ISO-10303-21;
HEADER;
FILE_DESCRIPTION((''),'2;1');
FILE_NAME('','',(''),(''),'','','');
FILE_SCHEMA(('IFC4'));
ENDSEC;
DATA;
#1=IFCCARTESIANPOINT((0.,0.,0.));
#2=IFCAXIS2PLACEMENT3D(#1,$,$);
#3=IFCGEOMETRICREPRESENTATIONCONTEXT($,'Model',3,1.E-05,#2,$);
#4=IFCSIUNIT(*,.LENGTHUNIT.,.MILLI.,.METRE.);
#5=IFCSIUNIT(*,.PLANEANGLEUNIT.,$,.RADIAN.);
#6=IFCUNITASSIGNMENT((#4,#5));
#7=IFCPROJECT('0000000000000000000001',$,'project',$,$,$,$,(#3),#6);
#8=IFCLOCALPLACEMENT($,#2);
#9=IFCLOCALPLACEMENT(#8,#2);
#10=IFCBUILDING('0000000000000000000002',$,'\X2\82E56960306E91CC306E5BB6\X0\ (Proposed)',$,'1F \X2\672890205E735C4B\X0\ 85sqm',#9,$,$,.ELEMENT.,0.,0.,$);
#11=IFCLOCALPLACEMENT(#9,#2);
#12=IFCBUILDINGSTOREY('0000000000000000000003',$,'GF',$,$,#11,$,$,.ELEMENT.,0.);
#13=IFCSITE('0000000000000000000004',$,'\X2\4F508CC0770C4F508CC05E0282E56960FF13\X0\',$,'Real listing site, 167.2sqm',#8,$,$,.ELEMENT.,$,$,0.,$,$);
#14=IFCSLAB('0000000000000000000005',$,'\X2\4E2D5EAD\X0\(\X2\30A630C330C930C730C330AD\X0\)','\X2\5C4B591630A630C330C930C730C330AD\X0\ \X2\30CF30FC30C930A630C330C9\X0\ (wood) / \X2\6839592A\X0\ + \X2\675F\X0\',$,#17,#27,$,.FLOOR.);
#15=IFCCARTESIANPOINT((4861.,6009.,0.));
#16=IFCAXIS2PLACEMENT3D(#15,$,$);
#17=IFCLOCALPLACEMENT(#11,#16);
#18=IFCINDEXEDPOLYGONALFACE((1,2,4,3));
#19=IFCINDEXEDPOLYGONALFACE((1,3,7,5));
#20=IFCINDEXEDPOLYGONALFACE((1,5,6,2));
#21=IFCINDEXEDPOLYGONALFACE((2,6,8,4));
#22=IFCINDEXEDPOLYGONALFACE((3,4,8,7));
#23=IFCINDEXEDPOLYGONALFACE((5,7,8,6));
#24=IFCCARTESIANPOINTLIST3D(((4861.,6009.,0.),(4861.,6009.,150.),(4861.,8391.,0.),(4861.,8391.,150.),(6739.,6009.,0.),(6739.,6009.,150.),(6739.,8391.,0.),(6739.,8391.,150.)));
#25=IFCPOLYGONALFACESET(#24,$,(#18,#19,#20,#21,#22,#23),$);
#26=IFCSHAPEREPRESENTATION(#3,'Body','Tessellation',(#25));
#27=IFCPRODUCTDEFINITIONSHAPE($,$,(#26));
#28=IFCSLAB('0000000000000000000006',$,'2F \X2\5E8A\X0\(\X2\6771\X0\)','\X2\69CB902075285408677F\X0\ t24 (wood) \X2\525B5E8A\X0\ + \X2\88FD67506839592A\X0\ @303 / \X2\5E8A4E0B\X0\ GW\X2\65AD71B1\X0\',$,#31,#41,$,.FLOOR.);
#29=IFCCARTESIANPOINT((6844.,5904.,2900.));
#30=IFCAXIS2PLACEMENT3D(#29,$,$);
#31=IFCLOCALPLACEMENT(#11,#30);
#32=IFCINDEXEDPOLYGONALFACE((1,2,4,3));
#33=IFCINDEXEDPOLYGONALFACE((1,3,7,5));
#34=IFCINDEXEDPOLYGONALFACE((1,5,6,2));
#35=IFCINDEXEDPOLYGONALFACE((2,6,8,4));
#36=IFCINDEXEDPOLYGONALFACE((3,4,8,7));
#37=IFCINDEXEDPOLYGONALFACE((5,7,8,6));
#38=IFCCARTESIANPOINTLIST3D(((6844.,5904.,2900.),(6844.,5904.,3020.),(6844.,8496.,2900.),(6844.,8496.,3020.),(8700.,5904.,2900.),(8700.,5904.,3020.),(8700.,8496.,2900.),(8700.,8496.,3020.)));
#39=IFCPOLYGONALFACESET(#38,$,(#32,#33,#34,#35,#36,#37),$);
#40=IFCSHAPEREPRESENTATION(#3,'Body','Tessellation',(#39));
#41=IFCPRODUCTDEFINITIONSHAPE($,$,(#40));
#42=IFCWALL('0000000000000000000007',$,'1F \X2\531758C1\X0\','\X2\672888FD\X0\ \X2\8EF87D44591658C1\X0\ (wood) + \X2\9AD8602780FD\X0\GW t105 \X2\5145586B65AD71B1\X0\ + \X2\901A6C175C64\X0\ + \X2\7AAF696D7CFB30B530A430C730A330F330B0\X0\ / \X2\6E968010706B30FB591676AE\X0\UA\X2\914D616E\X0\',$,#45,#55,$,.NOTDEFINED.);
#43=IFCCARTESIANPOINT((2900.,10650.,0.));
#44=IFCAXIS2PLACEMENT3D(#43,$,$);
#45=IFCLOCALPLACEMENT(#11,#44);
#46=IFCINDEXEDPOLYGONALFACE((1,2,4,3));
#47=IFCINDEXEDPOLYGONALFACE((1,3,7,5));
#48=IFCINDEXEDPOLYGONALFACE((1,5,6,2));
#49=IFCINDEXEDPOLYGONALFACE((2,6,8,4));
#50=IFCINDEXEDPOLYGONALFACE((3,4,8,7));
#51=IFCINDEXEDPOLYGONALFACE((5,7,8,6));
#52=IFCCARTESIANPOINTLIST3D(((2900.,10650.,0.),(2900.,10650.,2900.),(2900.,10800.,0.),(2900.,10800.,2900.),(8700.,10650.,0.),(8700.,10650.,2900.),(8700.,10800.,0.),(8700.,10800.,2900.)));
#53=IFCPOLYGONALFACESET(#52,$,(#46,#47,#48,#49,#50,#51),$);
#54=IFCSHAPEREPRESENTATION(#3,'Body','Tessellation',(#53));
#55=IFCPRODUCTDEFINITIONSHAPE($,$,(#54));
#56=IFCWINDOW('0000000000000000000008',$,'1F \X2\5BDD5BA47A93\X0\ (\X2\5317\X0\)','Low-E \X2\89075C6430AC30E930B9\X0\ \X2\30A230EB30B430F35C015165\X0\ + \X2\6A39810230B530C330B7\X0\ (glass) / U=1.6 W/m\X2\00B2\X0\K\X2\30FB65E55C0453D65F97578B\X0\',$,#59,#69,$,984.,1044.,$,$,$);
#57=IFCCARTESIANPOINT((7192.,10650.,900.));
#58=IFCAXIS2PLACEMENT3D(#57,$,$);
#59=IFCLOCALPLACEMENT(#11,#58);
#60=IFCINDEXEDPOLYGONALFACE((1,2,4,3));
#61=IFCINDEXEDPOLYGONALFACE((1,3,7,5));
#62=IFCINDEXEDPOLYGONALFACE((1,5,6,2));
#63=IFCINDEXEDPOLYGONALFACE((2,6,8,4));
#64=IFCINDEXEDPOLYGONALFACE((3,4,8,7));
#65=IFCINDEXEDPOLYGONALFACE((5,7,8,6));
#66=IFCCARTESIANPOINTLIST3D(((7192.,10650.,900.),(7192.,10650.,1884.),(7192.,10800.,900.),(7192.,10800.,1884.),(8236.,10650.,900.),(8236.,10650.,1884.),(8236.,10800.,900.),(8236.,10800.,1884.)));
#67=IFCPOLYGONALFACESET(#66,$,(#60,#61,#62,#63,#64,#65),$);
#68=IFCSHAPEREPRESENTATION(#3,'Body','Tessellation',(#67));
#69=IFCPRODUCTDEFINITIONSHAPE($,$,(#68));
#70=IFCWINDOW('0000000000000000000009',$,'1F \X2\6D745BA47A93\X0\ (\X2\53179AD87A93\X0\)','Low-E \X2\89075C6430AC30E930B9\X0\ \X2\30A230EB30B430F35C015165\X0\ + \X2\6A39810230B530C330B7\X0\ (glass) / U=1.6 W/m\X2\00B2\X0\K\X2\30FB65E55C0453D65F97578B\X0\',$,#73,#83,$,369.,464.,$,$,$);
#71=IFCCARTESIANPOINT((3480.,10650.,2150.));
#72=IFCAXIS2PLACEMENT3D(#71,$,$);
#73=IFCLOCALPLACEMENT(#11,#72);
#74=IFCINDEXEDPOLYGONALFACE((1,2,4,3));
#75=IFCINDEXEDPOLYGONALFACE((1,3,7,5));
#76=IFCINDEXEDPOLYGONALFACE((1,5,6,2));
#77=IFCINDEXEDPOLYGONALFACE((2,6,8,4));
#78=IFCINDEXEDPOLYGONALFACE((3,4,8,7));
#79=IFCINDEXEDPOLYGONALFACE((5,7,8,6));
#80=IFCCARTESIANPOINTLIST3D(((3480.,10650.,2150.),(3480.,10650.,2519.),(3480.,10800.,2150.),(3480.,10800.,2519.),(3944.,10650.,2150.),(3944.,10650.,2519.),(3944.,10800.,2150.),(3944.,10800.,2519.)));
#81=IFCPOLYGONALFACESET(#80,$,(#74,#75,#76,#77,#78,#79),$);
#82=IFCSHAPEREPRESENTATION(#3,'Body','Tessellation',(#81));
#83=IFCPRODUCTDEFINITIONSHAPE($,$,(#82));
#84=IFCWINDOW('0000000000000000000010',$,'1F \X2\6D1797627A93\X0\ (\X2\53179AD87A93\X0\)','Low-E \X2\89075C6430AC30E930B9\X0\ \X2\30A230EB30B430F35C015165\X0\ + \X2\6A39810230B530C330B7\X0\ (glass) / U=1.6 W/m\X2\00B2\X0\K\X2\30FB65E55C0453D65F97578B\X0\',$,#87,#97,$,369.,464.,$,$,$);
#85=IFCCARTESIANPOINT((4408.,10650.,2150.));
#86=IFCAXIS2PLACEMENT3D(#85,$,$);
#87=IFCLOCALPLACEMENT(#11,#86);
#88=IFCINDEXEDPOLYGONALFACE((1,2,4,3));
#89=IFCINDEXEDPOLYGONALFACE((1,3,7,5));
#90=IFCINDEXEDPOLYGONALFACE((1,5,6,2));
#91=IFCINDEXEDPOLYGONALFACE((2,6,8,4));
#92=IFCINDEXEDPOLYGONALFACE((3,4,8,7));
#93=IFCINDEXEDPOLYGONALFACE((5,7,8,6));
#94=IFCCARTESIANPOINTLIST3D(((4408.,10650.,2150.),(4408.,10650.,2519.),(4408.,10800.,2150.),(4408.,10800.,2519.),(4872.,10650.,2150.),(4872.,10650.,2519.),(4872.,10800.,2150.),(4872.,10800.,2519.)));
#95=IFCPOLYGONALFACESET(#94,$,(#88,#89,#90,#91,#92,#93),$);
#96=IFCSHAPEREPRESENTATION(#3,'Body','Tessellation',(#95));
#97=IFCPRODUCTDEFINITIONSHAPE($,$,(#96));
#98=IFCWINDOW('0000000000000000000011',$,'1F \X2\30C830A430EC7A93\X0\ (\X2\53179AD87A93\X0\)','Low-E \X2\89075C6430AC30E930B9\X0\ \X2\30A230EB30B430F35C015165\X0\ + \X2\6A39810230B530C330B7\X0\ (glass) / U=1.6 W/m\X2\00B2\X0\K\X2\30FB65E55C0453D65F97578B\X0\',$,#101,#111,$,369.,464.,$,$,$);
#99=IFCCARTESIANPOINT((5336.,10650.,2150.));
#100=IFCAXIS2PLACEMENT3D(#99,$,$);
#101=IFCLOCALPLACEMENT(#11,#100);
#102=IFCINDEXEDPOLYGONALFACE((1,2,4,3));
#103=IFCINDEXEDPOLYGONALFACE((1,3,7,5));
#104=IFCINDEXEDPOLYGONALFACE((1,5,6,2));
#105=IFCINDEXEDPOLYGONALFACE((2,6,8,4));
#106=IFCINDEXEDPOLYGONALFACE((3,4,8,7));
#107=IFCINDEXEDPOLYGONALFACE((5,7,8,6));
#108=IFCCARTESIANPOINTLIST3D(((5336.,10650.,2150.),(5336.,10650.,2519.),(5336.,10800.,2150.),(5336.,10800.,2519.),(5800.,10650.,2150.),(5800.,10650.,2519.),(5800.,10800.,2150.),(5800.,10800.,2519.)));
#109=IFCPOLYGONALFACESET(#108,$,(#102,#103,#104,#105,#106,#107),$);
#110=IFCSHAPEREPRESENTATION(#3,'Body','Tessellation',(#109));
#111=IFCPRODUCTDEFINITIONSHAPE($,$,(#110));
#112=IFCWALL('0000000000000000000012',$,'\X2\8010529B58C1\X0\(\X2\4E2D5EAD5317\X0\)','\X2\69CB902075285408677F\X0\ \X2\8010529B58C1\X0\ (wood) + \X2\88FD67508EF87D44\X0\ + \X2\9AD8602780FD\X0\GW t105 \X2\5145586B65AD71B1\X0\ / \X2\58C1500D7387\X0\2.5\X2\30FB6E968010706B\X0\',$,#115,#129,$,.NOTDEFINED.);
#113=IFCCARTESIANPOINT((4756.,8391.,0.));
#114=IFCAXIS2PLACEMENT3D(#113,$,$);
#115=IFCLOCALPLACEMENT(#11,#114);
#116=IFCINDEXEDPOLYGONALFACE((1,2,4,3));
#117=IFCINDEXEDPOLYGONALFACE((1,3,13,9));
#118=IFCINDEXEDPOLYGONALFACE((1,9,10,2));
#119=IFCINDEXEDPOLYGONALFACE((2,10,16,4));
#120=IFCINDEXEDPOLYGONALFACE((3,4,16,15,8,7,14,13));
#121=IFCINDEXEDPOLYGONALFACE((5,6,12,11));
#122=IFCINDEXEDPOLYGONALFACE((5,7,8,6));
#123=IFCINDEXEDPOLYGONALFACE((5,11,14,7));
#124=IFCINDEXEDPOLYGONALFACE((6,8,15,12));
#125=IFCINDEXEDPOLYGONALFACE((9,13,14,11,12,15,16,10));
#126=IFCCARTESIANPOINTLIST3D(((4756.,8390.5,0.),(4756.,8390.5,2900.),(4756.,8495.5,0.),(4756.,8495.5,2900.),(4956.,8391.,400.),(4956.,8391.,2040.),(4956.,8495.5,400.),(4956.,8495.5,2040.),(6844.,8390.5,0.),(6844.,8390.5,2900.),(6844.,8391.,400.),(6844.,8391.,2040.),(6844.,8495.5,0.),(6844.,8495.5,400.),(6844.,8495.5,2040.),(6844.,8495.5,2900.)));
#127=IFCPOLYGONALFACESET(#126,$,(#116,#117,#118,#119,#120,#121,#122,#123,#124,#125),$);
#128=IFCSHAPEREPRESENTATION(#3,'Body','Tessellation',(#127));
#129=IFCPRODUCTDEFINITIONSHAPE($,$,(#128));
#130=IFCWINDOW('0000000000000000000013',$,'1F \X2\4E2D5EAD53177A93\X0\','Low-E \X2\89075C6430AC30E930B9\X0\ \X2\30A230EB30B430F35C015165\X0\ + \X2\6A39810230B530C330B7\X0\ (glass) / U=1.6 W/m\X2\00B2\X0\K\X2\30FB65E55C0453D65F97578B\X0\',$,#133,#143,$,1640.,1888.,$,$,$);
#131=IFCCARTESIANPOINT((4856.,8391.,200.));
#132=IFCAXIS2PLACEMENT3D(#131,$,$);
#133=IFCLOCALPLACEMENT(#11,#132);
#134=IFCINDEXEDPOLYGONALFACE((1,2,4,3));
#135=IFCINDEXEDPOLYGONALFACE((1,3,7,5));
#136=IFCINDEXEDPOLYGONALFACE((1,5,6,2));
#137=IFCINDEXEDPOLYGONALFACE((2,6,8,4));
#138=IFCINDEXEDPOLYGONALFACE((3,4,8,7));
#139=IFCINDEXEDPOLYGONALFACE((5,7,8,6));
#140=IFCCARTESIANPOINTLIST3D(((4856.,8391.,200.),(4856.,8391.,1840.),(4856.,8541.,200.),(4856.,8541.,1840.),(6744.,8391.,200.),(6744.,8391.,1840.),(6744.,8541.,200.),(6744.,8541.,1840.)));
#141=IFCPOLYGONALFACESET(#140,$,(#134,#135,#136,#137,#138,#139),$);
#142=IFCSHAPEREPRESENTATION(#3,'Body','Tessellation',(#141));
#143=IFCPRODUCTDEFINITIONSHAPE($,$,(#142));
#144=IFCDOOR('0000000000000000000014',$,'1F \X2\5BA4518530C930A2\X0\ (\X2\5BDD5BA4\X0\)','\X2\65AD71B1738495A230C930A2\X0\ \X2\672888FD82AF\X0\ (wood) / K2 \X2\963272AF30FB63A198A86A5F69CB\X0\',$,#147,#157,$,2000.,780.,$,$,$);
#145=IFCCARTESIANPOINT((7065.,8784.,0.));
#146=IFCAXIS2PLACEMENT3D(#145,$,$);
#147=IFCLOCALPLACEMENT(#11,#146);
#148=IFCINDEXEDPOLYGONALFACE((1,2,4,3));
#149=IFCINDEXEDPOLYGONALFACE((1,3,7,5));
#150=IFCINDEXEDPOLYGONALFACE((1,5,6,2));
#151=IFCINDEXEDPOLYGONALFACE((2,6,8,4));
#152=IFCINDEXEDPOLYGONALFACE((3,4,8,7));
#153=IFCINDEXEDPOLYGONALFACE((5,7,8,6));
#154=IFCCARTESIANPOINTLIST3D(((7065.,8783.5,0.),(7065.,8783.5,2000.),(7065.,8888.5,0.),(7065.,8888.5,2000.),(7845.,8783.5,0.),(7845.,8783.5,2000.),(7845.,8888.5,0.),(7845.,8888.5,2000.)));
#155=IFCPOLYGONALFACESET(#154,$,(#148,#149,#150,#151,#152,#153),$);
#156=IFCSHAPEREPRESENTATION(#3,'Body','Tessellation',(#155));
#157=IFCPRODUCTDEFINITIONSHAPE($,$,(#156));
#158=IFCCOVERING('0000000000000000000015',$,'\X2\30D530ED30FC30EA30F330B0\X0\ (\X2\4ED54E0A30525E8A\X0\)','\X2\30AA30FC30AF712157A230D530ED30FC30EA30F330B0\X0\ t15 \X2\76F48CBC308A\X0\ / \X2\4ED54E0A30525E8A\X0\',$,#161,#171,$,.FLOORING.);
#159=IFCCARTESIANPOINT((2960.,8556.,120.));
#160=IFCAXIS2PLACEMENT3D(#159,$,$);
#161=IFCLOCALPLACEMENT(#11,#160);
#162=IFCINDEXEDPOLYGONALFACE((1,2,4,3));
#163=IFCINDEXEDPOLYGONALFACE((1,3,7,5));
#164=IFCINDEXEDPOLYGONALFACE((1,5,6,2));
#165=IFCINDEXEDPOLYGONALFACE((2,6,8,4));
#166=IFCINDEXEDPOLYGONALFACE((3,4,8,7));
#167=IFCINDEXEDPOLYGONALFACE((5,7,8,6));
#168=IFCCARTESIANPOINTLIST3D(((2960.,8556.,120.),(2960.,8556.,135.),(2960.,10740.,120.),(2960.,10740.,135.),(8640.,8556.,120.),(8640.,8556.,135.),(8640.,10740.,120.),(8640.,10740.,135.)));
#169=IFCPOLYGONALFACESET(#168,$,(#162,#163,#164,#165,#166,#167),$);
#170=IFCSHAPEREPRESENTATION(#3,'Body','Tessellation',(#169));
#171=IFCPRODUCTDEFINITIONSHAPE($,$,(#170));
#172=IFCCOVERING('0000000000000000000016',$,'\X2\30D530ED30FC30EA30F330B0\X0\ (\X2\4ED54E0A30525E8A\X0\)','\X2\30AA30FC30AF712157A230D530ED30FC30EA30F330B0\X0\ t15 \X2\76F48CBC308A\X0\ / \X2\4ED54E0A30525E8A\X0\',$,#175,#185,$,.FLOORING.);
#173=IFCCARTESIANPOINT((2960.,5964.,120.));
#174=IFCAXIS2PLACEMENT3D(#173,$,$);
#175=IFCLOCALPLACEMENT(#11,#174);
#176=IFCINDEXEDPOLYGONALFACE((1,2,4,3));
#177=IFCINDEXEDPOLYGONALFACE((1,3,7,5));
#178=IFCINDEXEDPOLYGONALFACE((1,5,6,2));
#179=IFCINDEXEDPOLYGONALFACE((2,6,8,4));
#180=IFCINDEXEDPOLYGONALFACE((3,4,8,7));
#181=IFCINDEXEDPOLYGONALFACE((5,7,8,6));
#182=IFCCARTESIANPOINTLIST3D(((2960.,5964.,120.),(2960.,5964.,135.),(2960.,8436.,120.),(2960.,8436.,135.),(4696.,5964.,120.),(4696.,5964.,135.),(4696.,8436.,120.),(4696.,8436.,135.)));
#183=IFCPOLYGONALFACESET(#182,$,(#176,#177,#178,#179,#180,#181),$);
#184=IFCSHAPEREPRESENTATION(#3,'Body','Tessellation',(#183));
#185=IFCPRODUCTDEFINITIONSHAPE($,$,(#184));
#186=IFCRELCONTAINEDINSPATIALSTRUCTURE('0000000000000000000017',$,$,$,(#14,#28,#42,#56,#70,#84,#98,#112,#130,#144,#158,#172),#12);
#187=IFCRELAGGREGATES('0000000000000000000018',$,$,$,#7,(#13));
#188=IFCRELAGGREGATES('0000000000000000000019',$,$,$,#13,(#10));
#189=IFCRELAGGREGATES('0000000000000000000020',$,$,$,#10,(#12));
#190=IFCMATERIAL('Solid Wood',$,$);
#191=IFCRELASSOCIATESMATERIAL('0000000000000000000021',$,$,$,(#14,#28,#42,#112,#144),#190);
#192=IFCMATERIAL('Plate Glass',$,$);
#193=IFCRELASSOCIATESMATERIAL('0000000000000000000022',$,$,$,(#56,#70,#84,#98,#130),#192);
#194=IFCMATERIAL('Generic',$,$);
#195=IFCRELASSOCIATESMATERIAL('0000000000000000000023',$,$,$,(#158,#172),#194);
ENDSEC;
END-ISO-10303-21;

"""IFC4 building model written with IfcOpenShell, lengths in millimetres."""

from ifc_helpers import new_model, si_unit, frame, frame_2d, origin, place, context, project, spatial, rectangle, extrude, material, element, fill, save


model = new_model("IFC4")

# Units and contexts
model_context = context("Model", 3, precision=1e-05, world=origin())
ifc_project = project(units=[si_unit("LENGTHUNIT", "METRE", prefix="MILLI"), si_unit("PLANEANGLEUNIT", "RADIAN")], contexts=[model_context])

# Site, building, storey
site_placement = place(None, origin())
site = spatial("IfcSite", under=ifc_project, at=site_placement, Name="佐賀県佐賀市若楠３", ObjectType="Real listing site, 167.2sqm", CompositionType="ELEMENT", RefElevation=0.0)
building_placement = place(site_placement, origin())
building = spatial("IfcBuilding", under=site, at=building_placement, Name="若楠の里の家 (Proposed)", ObjectType="1F 木造平屋 85sqm", CompositionType="ELEMENT", ElevationOfRefHeight=0.0, ElevationOfTerrain=0.0)
storey_placement = place(building_placement, origin())
storey = spatial("IfcBuildingStorey", under=building, at=storey_placement, Name="GF", CompositionType="ELEMENT", Elevation=0.0)

# Slabs
ifc_material_1 = material(Name="Solid Wood")
slab_1_placement = place(storey_placement, frame((4861.0, 6009.0, 0.0)))
element("IfcSlab", 1, at=slab_1_placement, inside=storey, material=ifc_material_1, Name="中庭(ウッドデッキ)", Description="屋外ウッドデッキ ハードウッド (wood) / 根太 + 束", PredefinedType="FLOOR", context=model_context, shape_type="SweptSolid", body=[
    extrude(rectangle(XDim=1878.0, YDim=2382.0, at=frame_2d((939.0, 1191.0))), frame((4861.0, 6009.0, 0.0)), (0.0, 0.0, 1.0), 150.0),
])
slab_2_placement = place(storey_placement, frame((6844.0, 5904.0, 2900.0)))
element("IfcSlab", 2, at=slab_2_placement, inside=storey, material=ifc_material_1, Name="2F 床(東)", Description="構造用合板 t24 (wood) 剛床 + 製材根太 @303 / 床下 GW断熱", PredefinedType="FLOOR", context=model_context, shape_type="SweptSolid", body=[
    extrude(rectangle(XDim=1856.0, YDim=2592.0, at=frame_2d((928.0, 1296.0))), frame((6844.0, 5904.0, 2900.0)), (0.0, 0.0, 1.0), 120.0),
])

# Wall, openings, windows
wall_1_placement = place(storey_placement, frame((2900.0, 10650.0, 0.0)))
wall_1 = element("IfcWall", 3, at=wall_1_placement, inside=storey, material=ifc_material_1, Name="1F 北壁", Description="木製 軸組外壁 (wood) + 高性能GW t105 充填断熱 + 通気層 + 窯業系サイディング / 準耐火・外皮UA配慮", PredefinedType="NOTDEFINED", context=model_context, shape_type="SweptSolid", body=[
    extrude(rectangle(XDim=5800.0, YDim=150.0, at=frame_2d((2900.0, 75.0))), frame((2900.0, 10650.0, 0.0)), (0.0, 0.0, 1.0), 2900.0),
])
opening_1_placement = place(storey_placement, frame((7192.0, 10650.0, 900.0)))
opening_1 = element("IfcOpeningElement", 4, at=opening_1_placement, cuts=wall_1, PredefinedType="NOTDEFINED", context=model_context, shape_type="SweptSolid", body=[
    extrude(rectangle(XDim=1044.0, YDim=150.0, at=frame_2d((522.0, 75.0))), frame((7192.0, 10650.0, 900.0)), (0.0, 0.0, 1.0), 984.0),
])
opening_2_placement = place(storey_placement, frame((3480.0, 10650.0, 2150.0)))
opening_2 = element("IfcOpeningElement", 5, at=opening_2_placement, cuts=wall_1, PredefinedType="NOTDEFINED", context=model_context, shape_type="SweptSolid", body=[
    extrude(rectangle(XDim=464.0, YDim=150.0, at=frame_2d((232.0, 75.0))), frame((3480.0, 10650.0, 2150.0)), (0.0, 0.0, 1.0), 369.0),
])
opening_3_placement = place(storey_placement, frame((4408.0, 10650.0, 2150.0)))
opening_3 = element("IfcOpeningElement", 6, at=opening_3_placement, cuts=wall_1, PredefinedType="NOTDEFINED", context=model_context, shape_type="SweptSolid", body=[
    extrude(rectangle(XDim=464.0, YDim=150.0, at=frame_2d((232.0, 75.0))), frame((4408.0, 10650.0, 2150.0)), (0.0, 0.0, 1.0), 369.0),
])
opening_4_placement = place(storey_placement, frame((5336.0, 10650.0, 2150.0)))
opening_4 = element("IfcOpeningElement", 7, at=opening_4_placement, cuts=wall_1, PredefinedType="NOTDEFINED", context=model_context, shape_type="SweptSolid", body=[
    extrude(rectangle(XDim=464.0, YDim=150.0, at=frame_2d((232.0, 75.0))), frame((5336.0, 10650.0, 2150.0)), (0.0, 0.0, 1.0), 369.0),
])
ifc_material_2 = material(Name="Plate Glass")
window_1_placement = place(storey_placement, frame((7192.0, 10650.0, 900.0)))
window_1 = element("IfcWindow", 8, at=window_1_placement, inside=storey, material=ifc_material_2, Name="1F 寝室窓 (北)", Description="Low-E 複層ガラス アルゴン封入 + 樹脂サッシ (glass) / U=1.6 W/m²K・日射取得型", OverallHeight=984.0, OverallWidth=1044.0, context=model_context, shape_type="SweptSolid", body=[
    extrude(rectangle(XDim=1044.0, YDim=150.0, at=frame_2d((522.0, 75.0))), frame((7192.0, 10650.0, 900.0)), (0.0, 0.0, 1.0), 984.0),
])
fill(opening_1, window_1)
window_2_placement = place(storey_placement, frame((3480.0, 10650.0, 2150.0)))
window_2 = element("IfcWindow", 9, at=window_2_placement, inside=storey, material=ifc_material_2, Name="1F 浴室窓 (北高窓)", Description="Low-E 複層ガラス アルゴン封入 + 樹脂サッシ (glass) / U=1.6 W/m²K・日射取得型", OverallHeight=369.0, OverallWidth=464.0, context=model_context, shape_type="SweptSolid", body=[
    extrude(rectangle(XDim=464.0, YDim=150.0, at=frame_2d((232.0, 75.0))), frame((3480.0, 10650.0, 2150.0)), (0.0, 0.0, 1.0), 369.0),
])
fill(opening_2, window_2)
window_3_placement = place(storey_placement, frame((4408.0, 10650.0, 2150.0)))
window_3 = element("IfcWindow", 10, at=window_3_placement, inside=storey, material=ifc_material_2, Name="1F 洗面窓 (北高窓)", Description="Low-E 複層ガラス アルゴン封入 + 樹脂サッシ (glass) / U=1.6 W/m²K・日射取得型", OverallHeight=369.0, OverallWidth=464.0, context=model_context, shape_type="SweptSolid", body=[
    extrude(rectangle(XDim=464.0, YDim=150.0, at=frame_2d((232.0, 75.0))), frame((4408.0, 10650.0, 2150.0)), (0.0, 0.0, 1.0), 369.0),
])
fill(opening_3, window_3)
window_4_placement = place(storey_placement, frame((5336.0, 10650.0, 2150.0)))
window_4 = element("IfcWindow", 11, at=window_4_placement, inside=storey, material=ifc_material_2, Name="1F トイレ窓 (北高窓)", Description="Low-E 複層ガラス アルゴン封入 + 樹脂サッシ (glass) / U=1.6 W/m²K・日射取得型", OverallHeight=369.0, OverallWidth=464.0, context=model_context, shape_type="SweptSolid", body=[
    extrude(rectangle(XDim=464.0, YDim=150.0, at=frame_2d((232.0, 75.0))), frame((5336.0, 10650.0, 2150.0)), (0.0, 0.0, 1.0), 369.0),
])
fill(opening_4, window_4)

# Wall, opening, window
wall_2_placement = place(storey_placement, frame((4756.0, 8391.0, 0.0)))
wall_2 = element("IfcWall", 12, at=wall_2_placement, inside=storey, material=ifc_material_1, Name="耐力壁(中庭北)", Description="構造用合板 耐力壁 (wood) + 製材軸組 + 高性能GW t105 充填断熱 / 壁倍率2.5・準耐火", PredefinedType="NOTDEFINED", context=model_context, shape_type="SweptSolid", body=[
    extrude(rectangle(XDim=2088.0, YDim=105.0, at=frame_2d((1044.0, 52.0))), frame((4756.0, 8391.0, 0.0)), (0.0, 0.0, 1.0), 2900.0),
])
opening_5_placement = place(storey_placement, frame((4856.0, 8391.0, 200.0)))
opening_5 = element("IfcOpeningElement", 13, at=opening_5_placement, cuts=wall_2, PredefinedType="NOTDEFINED", context=model_context, shape_type="SweptSolid", body=[
    extrude(rectangle(XDim=1888.0, YDim=150.0, at=frame_2d((944.0, 75.0))), frame((4856.0, 8391.0, 200.0)), (0.0, 0.0, 1.0), 1640.0),
])
window_5_placement = place(storey_placement, frame((4856.0, 8391.0, 200.0)))
window_5 = element("IfcWindow", 14, at=window_5_placement, inside=storey, material=ifc_material_2, Name="1F 中庭北窓", Description="Low-E 複層ガラス アルゴン封入 + 樹脂サッシ (glass) / U=1.6 W/m²K・日射取得型", OverallHeight=1640.0, OverallWidth=1888.0, context=model_context, shape_type="SweptSolid", body=[
    extrude(rectangle(XDim=1888.0, YDim=150.0, at=frame_2d((944.0, 75.0))), frame((4856.0, 8391.0, 200.0)), (0.0, 0.0, 1.0), 1640.0),
])
fill(opening_5, window_5)

# Door
door_1_placement = place(storey_placement, frame((7065.0, 8784.0, 0.0)))
element("IfcDoor", 15, at=door_1_placement, inside=storey, material=ifc_material_1, Name="1F 室内ドア (寝室)", Description="断熱玄関ドア 木製芯 (wood) / K2 防犯・採風機構", OverallHeight=2000.0, OverallWidth=780.0, context=model_context, shape_type="SweptSolid", body=[
    extrude(rectangle(XDim=780.0, YDim=105.0, at=frame_2d((390.0, 52.0))), frame((7065.0, 8784.0, 0.0)), (0.0, 0.0, 1.0), 2000.0),
])

# Coverings
ifc_material_3 = material(Name="Generic")
covering_1_placement = place(storey_placement, frame((2960.0, 8556.0, 120.0)))
element("IfcCovering", 16, at=covering_1_placement, inside=storey, material=ifc_material_3, Name="フローリング (仕上げ床)", Description="オーク無垢フローリング t15 直貼り / 仕上げ床", PredefinedType="FLOORING", context=model_context, shape_type="SweptSolid", body=[
    extrude(rectangle(XDim=5680.0, YDim=2184.0, at=frame_2d((2840.0, 1092.0))), frame((2960.0, 8556.0, 120.0)), (0.0, 0.0, 1.0), 15.0),
])
covering_2_placement = place(storey_placement, frame((2960.0, 5964.0, 120.0)))
element("IfcCovering", 17, at=covering_2_placement, inside=storey, material=ifc_material_3, Name="フローリング (仕上げ床)", Description="オーク無垢フローリング t15 直貼り / 仕上げ床", PredefinedType="FLOORING", context=model_context, shape_type="SweptSolid", body=[
    extrude(rectangle(XDim=1736.0, YDim=2472.0, at=frame_2d((868.0, 1236.0))), frame((2960.0, 5964.0, 120.0)), (0.0, 0.0, 1.0), 15.0),
])

save(model, "model.ifc")
